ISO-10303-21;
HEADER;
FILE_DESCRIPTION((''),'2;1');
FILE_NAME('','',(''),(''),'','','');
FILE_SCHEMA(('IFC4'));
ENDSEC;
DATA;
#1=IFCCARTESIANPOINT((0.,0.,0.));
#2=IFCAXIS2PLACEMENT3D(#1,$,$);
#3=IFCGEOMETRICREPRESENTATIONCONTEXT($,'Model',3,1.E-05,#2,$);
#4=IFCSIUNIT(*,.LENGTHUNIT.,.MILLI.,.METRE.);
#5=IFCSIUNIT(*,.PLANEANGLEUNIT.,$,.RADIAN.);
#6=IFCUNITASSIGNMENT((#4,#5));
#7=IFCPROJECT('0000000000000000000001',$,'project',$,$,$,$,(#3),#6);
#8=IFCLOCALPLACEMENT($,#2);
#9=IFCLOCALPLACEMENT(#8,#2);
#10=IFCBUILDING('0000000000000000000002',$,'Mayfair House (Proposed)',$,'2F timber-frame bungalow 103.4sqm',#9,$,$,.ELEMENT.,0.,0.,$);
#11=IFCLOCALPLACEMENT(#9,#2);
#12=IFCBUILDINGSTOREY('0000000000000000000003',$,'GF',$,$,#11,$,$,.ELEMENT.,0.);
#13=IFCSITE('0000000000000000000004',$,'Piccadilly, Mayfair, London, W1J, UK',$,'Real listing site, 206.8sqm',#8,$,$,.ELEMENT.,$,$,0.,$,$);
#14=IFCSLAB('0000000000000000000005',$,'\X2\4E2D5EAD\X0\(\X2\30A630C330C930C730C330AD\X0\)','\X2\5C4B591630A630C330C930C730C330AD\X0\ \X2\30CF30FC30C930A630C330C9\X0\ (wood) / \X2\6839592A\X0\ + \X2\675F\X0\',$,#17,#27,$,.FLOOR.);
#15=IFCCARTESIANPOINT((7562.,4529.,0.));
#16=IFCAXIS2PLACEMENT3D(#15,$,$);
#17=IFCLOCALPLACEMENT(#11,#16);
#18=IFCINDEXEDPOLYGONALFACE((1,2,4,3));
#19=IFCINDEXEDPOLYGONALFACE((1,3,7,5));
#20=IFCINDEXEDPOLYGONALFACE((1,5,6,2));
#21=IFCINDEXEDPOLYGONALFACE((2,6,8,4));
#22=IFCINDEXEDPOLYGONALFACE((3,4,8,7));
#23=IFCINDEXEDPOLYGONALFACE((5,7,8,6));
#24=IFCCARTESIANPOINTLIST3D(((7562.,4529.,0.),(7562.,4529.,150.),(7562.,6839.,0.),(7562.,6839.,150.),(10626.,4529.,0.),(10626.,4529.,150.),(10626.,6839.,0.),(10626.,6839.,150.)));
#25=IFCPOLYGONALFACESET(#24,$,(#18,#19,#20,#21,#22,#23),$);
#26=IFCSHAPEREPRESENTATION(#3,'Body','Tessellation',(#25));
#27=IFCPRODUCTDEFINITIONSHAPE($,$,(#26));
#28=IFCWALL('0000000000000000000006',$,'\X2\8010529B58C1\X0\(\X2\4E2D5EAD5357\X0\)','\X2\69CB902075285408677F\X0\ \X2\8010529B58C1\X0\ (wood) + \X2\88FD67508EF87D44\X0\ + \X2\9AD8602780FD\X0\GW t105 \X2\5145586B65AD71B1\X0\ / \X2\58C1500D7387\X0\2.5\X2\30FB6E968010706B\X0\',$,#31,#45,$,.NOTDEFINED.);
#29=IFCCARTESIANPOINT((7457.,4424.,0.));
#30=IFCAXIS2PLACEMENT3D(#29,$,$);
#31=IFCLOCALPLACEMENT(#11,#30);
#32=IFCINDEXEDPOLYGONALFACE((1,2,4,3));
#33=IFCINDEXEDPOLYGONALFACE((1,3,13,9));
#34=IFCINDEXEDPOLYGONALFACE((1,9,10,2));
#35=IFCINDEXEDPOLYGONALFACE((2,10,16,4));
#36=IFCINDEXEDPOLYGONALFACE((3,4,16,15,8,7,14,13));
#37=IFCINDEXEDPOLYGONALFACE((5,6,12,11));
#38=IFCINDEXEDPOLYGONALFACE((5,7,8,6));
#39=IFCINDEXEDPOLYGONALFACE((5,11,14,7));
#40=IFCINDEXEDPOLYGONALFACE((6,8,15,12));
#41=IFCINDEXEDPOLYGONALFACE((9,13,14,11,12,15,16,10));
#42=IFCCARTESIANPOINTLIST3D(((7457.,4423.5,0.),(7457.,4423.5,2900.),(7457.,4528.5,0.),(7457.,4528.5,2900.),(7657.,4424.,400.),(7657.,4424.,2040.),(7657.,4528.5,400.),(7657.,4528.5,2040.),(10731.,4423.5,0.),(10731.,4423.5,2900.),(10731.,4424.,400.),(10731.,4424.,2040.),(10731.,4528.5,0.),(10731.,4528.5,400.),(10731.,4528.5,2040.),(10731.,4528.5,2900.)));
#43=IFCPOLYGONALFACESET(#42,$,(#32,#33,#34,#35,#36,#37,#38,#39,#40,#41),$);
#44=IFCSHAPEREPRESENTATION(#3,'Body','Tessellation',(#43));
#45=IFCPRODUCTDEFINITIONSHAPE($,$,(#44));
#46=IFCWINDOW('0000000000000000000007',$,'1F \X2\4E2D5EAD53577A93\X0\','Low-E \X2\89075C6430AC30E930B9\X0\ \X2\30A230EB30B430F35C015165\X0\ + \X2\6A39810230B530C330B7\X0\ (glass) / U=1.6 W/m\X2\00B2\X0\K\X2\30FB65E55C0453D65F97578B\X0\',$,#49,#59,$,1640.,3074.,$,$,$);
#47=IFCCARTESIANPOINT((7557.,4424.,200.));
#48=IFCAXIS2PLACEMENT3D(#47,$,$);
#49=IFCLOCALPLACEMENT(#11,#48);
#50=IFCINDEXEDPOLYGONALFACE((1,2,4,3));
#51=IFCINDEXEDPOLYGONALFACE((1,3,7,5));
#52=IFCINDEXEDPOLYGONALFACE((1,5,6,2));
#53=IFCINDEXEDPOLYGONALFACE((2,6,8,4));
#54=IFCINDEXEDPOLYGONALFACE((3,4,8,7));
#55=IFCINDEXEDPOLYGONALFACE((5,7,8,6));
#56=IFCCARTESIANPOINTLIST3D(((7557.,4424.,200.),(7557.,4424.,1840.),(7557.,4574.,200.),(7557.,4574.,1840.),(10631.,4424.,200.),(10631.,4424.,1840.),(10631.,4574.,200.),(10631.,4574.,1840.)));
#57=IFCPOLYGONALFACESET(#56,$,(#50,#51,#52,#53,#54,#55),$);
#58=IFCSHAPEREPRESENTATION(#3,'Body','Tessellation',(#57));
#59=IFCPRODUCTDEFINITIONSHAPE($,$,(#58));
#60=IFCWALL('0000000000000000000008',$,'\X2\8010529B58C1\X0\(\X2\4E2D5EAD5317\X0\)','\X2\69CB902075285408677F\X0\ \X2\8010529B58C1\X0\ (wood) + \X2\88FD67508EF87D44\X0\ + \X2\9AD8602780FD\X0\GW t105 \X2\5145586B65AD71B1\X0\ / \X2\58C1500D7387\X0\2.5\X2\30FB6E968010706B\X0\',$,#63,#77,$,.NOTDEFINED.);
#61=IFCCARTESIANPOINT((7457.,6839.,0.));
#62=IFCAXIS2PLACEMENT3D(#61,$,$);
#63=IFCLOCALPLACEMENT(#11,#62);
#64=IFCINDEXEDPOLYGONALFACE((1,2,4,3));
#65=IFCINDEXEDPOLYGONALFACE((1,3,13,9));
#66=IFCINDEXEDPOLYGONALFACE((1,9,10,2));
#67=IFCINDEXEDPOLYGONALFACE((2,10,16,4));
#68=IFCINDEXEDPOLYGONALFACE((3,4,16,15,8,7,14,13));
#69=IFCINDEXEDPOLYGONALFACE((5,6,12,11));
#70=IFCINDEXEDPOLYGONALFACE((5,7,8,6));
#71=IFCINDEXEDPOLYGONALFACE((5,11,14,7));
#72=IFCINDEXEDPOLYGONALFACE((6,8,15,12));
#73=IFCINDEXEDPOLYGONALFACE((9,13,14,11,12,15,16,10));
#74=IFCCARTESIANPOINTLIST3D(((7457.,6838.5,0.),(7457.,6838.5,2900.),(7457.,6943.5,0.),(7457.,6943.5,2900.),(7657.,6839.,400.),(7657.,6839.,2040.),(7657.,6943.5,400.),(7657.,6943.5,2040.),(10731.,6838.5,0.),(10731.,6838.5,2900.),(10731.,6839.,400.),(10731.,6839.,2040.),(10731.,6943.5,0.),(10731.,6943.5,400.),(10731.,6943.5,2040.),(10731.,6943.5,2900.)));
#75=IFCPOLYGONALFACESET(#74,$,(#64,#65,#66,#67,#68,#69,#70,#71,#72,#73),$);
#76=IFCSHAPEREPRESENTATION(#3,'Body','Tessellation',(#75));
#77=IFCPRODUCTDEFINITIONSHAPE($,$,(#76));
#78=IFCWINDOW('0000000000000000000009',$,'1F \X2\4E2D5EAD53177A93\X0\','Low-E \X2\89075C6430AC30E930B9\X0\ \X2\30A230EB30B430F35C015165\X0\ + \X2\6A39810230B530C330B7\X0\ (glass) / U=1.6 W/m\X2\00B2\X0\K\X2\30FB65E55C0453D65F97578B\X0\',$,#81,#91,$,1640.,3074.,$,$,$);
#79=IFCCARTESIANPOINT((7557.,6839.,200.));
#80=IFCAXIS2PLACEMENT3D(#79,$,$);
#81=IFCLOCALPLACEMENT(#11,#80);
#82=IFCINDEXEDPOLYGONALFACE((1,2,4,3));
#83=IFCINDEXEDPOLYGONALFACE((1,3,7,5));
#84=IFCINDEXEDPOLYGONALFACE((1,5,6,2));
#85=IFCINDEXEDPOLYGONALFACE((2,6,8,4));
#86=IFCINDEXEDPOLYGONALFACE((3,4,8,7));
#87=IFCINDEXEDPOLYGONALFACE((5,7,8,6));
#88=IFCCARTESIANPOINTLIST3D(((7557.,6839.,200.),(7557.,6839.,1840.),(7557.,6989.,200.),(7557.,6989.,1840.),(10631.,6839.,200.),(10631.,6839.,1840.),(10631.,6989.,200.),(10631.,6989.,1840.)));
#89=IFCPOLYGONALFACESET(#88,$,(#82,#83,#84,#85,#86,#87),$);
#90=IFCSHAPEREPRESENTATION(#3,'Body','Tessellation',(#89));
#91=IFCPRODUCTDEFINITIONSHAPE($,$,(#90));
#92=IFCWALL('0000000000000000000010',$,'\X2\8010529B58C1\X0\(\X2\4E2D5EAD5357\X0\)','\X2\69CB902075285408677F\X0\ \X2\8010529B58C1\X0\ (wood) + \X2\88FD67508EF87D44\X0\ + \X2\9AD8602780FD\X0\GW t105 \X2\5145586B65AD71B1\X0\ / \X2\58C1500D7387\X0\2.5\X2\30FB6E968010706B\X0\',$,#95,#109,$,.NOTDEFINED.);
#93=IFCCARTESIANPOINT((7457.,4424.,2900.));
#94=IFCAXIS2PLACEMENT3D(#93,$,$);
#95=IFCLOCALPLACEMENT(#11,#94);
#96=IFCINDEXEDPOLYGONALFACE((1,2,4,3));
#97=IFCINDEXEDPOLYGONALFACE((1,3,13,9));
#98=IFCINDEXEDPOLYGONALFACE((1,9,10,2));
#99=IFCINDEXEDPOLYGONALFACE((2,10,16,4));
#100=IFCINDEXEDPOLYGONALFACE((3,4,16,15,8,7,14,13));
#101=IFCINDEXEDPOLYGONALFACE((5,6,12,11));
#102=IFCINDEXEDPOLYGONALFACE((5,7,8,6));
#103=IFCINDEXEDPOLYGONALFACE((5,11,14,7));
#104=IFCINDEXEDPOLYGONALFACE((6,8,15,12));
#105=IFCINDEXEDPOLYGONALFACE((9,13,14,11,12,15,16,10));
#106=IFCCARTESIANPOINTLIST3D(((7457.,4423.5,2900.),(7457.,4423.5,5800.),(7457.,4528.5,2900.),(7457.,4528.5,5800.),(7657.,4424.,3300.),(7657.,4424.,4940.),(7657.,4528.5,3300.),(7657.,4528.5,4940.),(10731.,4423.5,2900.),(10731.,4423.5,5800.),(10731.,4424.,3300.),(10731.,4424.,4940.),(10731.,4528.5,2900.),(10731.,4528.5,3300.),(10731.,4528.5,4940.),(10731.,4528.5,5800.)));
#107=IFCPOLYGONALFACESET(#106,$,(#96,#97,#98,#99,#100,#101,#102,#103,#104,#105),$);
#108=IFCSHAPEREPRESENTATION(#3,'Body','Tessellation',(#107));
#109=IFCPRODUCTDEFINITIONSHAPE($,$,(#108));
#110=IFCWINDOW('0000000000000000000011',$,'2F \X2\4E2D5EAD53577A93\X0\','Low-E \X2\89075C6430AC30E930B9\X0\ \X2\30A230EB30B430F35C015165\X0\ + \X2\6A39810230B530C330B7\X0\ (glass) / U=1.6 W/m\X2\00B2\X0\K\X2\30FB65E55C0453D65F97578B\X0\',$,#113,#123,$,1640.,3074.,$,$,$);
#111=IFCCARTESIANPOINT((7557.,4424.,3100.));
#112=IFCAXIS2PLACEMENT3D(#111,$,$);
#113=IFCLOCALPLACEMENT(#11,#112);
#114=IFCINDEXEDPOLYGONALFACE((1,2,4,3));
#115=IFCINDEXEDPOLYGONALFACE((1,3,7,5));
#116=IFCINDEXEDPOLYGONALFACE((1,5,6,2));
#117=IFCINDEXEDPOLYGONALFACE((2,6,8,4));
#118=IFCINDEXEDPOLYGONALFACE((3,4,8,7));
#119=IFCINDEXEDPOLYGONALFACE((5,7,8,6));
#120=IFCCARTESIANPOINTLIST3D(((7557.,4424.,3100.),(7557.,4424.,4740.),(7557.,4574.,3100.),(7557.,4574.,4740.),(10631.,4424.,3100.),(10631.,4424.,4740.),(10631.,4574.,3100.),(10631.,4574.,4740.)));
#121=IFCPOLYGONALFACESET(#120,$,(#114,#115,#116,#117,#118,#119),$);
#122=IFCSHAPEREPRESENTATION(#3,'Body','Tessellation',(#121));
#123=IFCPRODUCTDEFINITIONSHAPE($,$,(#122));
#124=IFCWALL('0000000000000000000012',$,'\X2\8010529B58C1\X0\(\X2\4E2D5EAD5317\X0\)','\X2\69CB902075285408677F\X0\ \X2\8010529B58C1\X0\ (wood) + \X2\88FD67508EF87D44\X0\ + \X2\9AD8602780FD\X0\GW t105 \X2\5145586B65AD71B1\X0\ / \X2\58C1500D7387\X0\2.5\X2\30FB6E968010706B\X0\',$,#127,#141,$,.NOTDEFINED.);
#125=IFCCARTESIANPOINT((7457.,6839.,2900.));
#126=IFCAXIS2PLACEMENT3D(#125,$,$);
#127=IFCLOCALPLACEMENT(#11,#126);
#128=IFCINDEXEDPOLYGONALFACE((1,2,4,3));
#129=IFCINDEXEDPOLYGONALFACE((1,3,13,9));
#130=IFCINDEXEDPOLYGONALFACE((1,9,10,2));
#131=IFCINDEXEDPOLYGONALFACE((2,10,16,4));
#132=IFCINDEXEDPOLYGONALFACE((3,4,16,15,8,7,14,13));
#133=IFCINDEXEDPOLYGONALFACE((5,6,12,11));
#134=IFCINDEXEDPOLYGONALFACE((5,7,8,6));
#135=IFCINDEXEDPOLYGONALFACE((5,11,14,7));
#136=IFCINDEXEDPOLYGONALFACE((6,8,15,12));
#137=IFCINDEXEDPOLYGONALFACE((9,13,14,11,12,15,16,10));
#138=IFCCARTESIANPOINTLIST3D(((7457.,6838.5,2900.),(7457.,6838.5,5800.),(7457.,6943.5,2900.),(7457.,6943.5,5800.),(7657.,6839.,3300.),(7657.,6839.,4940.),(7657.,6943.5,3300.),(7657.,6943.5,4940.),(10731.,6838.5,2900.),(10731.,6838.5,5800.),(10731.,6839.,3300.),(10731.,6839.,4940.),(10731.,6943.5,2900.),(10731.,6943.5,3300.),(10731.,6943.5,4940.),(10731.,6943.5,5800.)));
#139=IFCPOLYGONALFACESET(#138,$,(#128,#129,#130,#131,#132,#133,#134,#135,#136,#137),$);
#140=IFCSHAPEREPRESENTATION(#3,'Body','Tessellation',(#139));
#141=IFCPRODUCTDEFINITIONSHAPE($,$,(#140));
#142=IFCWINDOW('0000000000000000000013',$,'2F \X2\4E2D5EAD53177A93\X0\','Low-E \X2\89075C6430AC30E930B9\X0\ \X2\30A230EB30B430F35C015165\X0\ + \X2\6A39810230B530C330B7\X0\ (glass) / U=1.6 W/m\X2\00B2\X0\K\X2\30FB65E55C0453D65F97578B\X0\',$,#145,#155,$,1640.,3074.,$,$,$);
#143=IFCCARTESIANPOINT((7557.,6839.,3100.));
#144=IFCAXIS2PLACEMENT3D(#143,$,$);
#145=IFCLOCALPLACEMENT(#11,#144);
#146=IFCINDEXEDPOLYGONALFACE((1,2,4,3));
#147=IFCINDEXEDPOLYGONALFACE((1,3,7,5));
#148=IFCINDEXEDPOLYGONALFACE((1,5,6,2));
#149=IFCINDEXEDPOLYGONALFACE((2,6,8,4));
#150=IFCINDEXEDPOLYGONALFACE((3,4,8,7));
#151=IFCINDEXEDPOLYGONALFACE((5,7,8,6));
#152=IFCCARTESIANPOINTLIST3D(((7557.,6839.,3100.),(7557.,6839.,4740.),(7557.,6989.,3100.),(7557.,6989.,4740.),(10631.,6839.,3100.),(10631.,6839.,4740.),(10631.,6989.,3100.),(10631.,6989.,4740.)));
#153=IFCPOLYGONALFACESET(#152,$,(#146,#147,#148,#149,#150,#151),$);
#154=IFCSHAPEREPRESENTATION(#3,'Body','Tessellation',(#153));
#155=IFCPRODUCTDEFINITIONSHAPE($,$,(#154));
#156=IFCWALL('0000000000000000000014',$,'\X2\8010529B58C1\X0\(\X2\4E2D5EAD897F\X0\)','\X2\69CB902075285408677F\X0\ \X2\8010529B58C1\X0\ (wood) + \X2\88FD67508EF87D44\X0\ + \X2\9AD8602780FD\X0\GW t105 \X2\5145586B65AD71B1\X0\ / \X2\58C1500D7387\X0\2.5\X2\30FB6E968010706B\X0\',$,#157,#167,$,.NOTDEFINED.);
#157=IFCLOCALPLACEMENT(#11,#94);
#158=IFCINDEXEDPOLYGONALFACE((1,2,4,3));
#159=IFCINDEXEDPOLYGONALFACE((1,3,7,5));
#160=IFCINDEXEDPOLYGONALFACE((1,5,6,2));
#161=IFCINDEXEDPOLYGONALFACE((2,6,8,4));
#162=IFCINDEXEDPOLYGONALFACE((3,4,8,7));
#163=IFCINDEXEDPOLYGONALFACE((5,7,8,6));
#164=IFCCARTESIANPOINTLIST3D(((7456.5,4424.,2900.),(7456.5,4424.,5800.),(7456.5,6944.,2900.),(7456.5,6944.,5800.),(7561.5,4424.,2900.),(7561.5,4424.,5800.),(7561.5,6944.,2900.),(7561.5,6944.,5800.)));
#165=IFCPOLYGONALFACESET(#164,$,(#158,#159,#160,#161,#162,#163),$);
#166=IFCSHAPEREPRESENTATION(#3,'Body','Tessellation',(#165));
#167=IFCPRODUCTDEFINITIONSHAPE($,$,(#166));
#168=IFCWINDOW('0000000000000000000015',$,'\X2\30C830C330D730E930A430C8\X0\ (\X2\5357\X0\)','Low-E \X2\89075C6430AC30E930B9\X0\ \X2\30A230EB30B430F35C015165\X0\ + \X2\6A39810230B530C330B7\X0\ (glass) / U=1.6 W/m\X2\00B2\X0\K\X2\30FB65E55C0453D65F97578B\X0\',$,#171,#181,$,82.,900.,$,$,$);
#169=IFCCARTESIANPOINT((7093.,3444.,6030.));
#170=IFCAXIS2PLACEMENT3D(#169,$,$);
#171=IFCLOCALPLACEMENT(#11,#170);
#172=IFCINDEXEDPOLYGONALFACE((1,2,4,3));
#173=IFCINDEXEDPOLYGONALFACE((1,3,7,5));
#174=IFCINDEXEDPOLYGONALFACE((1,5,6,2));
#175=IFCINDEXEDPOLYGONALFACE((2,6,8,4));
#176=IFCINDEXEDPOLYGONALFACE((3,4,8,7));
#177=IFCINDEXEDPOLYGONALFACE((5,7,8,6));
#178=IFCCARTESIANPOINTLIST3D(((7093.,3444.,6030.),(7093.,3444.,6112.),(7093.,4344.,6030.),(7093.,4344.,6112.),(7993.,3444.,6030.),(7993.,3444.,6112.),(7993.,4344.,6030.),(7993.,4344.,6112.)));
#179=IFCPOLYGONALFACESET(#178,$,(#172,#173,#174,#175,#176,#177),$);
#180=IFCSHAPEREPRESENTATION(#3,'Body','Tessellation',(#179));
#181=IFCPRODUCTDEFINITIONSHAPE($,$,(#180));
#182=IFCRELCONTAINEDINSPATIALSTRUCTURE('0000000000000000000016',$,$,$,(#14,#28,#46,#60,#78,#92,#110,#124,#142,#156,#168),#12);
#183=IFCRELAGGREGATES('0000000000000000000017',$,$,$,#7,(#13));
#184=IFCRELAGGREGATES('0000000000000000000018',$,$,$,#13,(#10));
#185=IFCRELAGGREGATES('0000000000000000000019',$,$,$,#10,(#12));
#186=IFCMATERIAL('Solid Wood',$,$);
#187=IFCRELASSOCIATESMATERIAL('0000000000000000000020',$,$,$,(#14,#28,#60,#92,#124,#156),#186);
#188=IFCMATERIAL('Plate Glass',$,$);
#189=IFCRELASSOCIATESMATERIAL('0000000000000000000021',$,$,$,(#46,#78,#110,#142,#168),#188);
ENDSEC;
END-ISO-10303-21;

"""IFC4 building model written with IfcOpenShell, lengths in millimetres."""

from ifc_helpers import new_model, si_unit, frame, frame_2d, origin, place, context, project, spatial, rectangle, extrude, material, element, fill, save


model = new_model("IFC4")

# Units and contexts
model_context = context("Model", 3, precision=1e-05, world=origin())
ifc_project = project(units=[si_unit("LENGTHUNIT", "METRE", prefix="MILLI"), si_unit("PLANEANGLEUNIT", "RADIAN")], contexts=[model_context])

# Site, building, storey
site_placement = place(None, origin())
site = spatial("IfcSite", under=ifc_project, at=site_placement, Name="Piccadilly, Mayfair, London, W1J, UK", ObjectType="Real listing site, 206.8sqm", CompositionType="ELEMENT", RefElevation=0.0)
building_placement = place(site_placement, origin())
building = spatial("IfcBuilding", under=site, at=building_placement, Name="Mayfair House (Proposed)", ObjectType="2F timber-frame bungalow 103.4sqm", CompositionType="ELEMENT", ElevationOfRefHeight=0.0, ElevationOfTerrain=0.0)
storey_placement = place(building_placement, origin())
storey = spatial("IfcBuildingStorey", under=building, at=storey_placement, Name="GF", CompositionType="ELEMENT", Elevation=0.0)

# Slab
ifc_material_1 = material(Name="Solid Wood")
slab_placement = place(storey_placement, frame((7562.0, 4529.0, 0.0)))
element("IfcSlab", 1, at=slab_placement, inside=storey, material=ifc_material_1, Name="中庭(ウッドデッキ)", Description="屋外ウッドデッキ ハードウッド (wood) / 根太 + 束", PredefinedType="FLOOR", context=model_context, shape_type="SweptSolid", body=[
    extrude(rectangle(XDim=3064.0, YDim=2310.0, at=frame_2d((1532.0, 1155.0))), frame((7562.0, 4529.0, 0.0)), (0.0, 0.0, 1.0), 150.0),
])

# Walls, openings, windows
wall_1_placement = place(storey_placement, frame((7457.0, 4424.0, 0.0)))
wall_1 = element("IfcWall", 2, at=wall_1_placement, inside=storey, material=ifc_material_1, Name="耐力壁(中庭南)", Description="構造用合板 耐力壁 (wood) + 製材軸組 + 高性能GW t105 充填断熱 / 壁倍率2.5・準耐火", PredefinedType="NOTDEFINED", context=model_context, shape_type="SweptSolid", body=[
    extrude(rectangle(XDim=3274.0, YDim=105.0, at=frame_2d((1637.0, 52.0))), frame((7457.0, 4424.0, 0.0)), (0.0, 0.0, 1.0), 2900.0),
])
opening_1_placement = place(storey_placement, frame((7557.0, 4424.0, 200.0)))
opening_1 = element("IfcOpeningElement", 3, at=opening_1_placement, cuts=wall_1, PredefinedType="NOTDEFINED", context=model_context, shape_type="SweptSolid", body=[
    extrude(rectangle(XDim=3074.0, YDim=150.0, at=frame_2d((1537.0, 75.0))), frame((7557.0, 4424.0, 200.0)), (0.0, 0.0, 1.0), 1640.0),
])
ifc_material_2 = material(Name="Plate Glass")
window_1_placement = place(storey_placement, frame((7557.0, 4424.0, 200.0)))
window_1 = element("IfcWindow", 4, at=window_1_placement, inside=storey, material=ifc_material_2, Name="1F 中庭南窓", Description="Low-E 複層ガラス アルゴン封入 + 樹脂サッシ (glass) / U=1.6 W/m²K・日射取得型", OverallHeight=1640.0, OverallWidth=3074.0, context=model_context, shape_type="SweptSolid", body=[
    extrude(rectangle(XDim=3074.0, YDim=150.0, at=frame_2d((1537.0, 75.0))), frame((7557.0, 4424.0, 200.0)), (0.0, 0.0, 1.0), 1640.0),
])
fill(opening_1, window_1)
wall_2_placement = place(storey_placement, frame((7457.0, 6839.0, 0.0)))
wall_2 = element("IfcWall", 5, at=wall_2_placement, inside=storey, material=ifc_material_1, Name="耐力壁(中庭北)", Description="構造用合板 耐力壁 (wood) + 製材軸組 + 高性能GW t105 充填断熱 / 壁倍率2.5・準耐火", PredefinedType="NOTDEFINED", context=model_context, shape_type="SweptSolid", body=[
    extrude(rectangle(XDim=3274.0, YDim=105.0, at=frame_2d((1637.0, 52.0))), frame((7457.0, 6839.0, 0.0)), (0.0, 0.0, 1.0), 2900.0),
])
opening_2_placement = place(storey_placement, frame((7557.0, 6839.0, 200.0)))
opening_2 = element("IfcOpeningElement", 6, at=opening_2_placement, cuts=wall_2, PredefinedType="NOTDEFINED", context=model_context, shape_type="SweptSolid", body=[
    extrude(rectangle(XDim=3074.0, YDim=150.0, at=frame_2d((1537.0, 75.0))), frame((7557.0, 6839.0, 200.0)), (0.0, 0.0, 1.0), 1640.0),
])
window_2_placement = place(storey_placement, frame((7557.0, 6839.0, 200.0)))
window_2 = element("IfcWindow", 7, at=window_2_placement, inside=storey, material=ifc_material_2, Name="1F 中庭北窓", Description="Low-E 複層ガラス アルゴン封入 + 樹脂サッシ (glass) / U=1.6 W/m²K・日射取得型", OverallHeight=1640.0, OverallWidth=3074.0, context=model_context, shape_type="SweptSolid", body=[
    extrude(rectangle(XDim=3074.0, YDim=150.0, at=frame_2d((1537.0, 75.0))), frame((7557.0, 6839.0, 200.0)), (0.0, 0.0, 1.0), 1640.0),
])
fill(opening_2, window_2)

# Walls, openings, windows
wall_3_placement = place(storey_placement, frame((7457.0, 4424.0, 2900.0)))
wall_3 = element("IfcWall", 8, at=wall_3_placement, inside=storey, material=ifc_material_1, Name="耐力壁(中庭南)", Description="構造用合板 耐力壁 (wood) + 製材軸組 + 高性能GW t105 充填断熱 / 壁倍率2.5・準耐火", PredefinedType="NOTDEFINED", context=model_context, shape_type="SweptSolid", body=[
    extrude(rectangle(XDim=3274.0, YDim=105.0, at=frame_2d((1637.0, 52.0))), frame((7457.0, 4424.0, 2900.0)), (0.0, 0.0, 1.0), 2900.0),
])
opening_3_placement = place(storey_placement, frame((7557.0, 4424.0, 3100.0)))
opening_3 = element("IfcOpeningElement", 9, at=opening_3_placement, cuts=wall_3, PredefinedType="NOTDEFINED", context=model_context, shape_type="SweptSolid", body=[
    extrude(rectangle(XDim=3074.0, YDim=150.0, at=frame_2d((1537.0, 75.0))), frame((7557.0, 4424.0, 3100.0)), (0.0, 0.0, 1.0), 1640.0),
])
window_3_placement = place(storey_placement, frame((7557.0, 4424.0, 3100.0)))
window_3 = element("IfcWindow", 10, at=window_3_placement, inside=storey, material=ifc_material_2, Name="2F 中庭南窓", Description="Low-E 複層ガラス アルゴン封入 + 樹脂サッシ (glass) / U=1.6 W/m²K・日射取得型", OverallHeight=1640.0, OverallWidth=3074.0, context=model_context, shape_type="SweptSolid", body=[
    extrude(rectangle(XDim=3074.0, YDim=150.0, at=frame_2d((1537.0, 75.0))), frame((7557.0, 4424.0, 3100.0)), (0.0, 0.0, 1.0), 1640.0),
])
fill(opening_3, window_3)
wall_4_placement = place(storey_placement, frame((7457.0, 6839.0, 2900.0)))
wall_4 = element("IfcWall", 11, at=wall_4_placement, inside=storey, material=ifc_material_1, Name="耐力壁(中庭北)", Description="構造用合板 耐力壁 (wood) + 製材軸組 + 高性能GW t105 充填断熱 / 壁倍率2.5・準耐火", PredefinedType="NOTDEFINED", context=model_context, shape_type="SweptSolid", body=[
    extrude(rectangle(XDim=3274.0, YDim=105.0, at=frame_2d((1637.0, 52.0))), frame((7457.0, 6839.0, 2900.0)), (0.0, 0.0, 1.0), 2900.0),
])
opening_4_placement = place(storey_placement, frame((7557.0, 6839.0, 3100.0)))
opening_4 = element("IfcOpeningElement", 12, at=opening_4_placement, cuts=wall_4, PredefinedType="NOTDEFINED", context=model_context, shape_type="SweptSolid", body=[
    extrude(rectangle(XDim=3074.0, YDim=150.0, at=frame_2d((1537.0, 75.0))), frame((7557.0, 6839.0, 3100.0)), (0.0, 0.0, 1.0), 1640.0),
])
window_4_placement = place(storey_placement, frame((7557.0, 6839.0, 3100.0)))
window_4 = element("IfcWindow", 13, at=window_4_placement, inside=storey, material=ifc_material_2, Name="2F 中庭北窓", Description="Low-E 複層ガラス アルゴン封入 + 樹脂サッシ (glass) / U=1.6 W/m²K・日射取得型", OverallHeight=1640.0, OverallWidth=3074.0, context=model_context, shape_type="SweptSolid", body=[
    extrude(rectangle(XDim=3074.0, YDim=150.0, at=frame_2d((1537.0, 75.0))), frame((7557.0, 6839.0, 3100.0)), (0.0, 0.0, 1.0), 1640.0),
])
fill(opening_4, window_4)

# Wall
wall_5_placement = place(storey_placement, frame((7457.0, 4424.0, 2900.0)))
element("IfcWall", 14, at=wall_5_placement, inside=storey, material=ifc_material_1, Name="耐力壁(中庭西)", Description="構造用合板 耐力壁 (wood) + 製材軸組 + 高性能GW t105 充填断熱 / 壁倍率2.5・準耐火", PredefinedType="NOTDEFINED", context=model_context, shape_type="SweptSolid", body=[
    extrude(rectangle(XDim=105.0, YDim=2520.0, at=frame_2d((52.0, 1260.0))), frame((7457.0, 4424.0, 2900.0)), (0.0, 0.0, 1.0), 2900.0),
])

# Window
window_5_placement = place(storey_placement, frame((7093.0, 3444.0, 6030.0)))
element("IfcWindow", 15, at=window_5_placement, inside=storey, material=ifc_material_2, Name="トップライト (南)", Description="Low-E 複層ガラス アルゴン封入 + 樹脂サッシ (glass) / U=1.6 W/m²K・日射取得型", OverallHeight=82.0, OverallWidth=900.0, context=model_context, shape_type="SweptSolid", body=[
    extrude(rectangle(XDim=900.0, YDim=900.0, at=frame_2d((450.0, 450.0))), frame((7093.0, 3444.0, 6030.0)), (0.0, 0.0, 1.0), 82.0),
])

save(model, "model.ifc")
